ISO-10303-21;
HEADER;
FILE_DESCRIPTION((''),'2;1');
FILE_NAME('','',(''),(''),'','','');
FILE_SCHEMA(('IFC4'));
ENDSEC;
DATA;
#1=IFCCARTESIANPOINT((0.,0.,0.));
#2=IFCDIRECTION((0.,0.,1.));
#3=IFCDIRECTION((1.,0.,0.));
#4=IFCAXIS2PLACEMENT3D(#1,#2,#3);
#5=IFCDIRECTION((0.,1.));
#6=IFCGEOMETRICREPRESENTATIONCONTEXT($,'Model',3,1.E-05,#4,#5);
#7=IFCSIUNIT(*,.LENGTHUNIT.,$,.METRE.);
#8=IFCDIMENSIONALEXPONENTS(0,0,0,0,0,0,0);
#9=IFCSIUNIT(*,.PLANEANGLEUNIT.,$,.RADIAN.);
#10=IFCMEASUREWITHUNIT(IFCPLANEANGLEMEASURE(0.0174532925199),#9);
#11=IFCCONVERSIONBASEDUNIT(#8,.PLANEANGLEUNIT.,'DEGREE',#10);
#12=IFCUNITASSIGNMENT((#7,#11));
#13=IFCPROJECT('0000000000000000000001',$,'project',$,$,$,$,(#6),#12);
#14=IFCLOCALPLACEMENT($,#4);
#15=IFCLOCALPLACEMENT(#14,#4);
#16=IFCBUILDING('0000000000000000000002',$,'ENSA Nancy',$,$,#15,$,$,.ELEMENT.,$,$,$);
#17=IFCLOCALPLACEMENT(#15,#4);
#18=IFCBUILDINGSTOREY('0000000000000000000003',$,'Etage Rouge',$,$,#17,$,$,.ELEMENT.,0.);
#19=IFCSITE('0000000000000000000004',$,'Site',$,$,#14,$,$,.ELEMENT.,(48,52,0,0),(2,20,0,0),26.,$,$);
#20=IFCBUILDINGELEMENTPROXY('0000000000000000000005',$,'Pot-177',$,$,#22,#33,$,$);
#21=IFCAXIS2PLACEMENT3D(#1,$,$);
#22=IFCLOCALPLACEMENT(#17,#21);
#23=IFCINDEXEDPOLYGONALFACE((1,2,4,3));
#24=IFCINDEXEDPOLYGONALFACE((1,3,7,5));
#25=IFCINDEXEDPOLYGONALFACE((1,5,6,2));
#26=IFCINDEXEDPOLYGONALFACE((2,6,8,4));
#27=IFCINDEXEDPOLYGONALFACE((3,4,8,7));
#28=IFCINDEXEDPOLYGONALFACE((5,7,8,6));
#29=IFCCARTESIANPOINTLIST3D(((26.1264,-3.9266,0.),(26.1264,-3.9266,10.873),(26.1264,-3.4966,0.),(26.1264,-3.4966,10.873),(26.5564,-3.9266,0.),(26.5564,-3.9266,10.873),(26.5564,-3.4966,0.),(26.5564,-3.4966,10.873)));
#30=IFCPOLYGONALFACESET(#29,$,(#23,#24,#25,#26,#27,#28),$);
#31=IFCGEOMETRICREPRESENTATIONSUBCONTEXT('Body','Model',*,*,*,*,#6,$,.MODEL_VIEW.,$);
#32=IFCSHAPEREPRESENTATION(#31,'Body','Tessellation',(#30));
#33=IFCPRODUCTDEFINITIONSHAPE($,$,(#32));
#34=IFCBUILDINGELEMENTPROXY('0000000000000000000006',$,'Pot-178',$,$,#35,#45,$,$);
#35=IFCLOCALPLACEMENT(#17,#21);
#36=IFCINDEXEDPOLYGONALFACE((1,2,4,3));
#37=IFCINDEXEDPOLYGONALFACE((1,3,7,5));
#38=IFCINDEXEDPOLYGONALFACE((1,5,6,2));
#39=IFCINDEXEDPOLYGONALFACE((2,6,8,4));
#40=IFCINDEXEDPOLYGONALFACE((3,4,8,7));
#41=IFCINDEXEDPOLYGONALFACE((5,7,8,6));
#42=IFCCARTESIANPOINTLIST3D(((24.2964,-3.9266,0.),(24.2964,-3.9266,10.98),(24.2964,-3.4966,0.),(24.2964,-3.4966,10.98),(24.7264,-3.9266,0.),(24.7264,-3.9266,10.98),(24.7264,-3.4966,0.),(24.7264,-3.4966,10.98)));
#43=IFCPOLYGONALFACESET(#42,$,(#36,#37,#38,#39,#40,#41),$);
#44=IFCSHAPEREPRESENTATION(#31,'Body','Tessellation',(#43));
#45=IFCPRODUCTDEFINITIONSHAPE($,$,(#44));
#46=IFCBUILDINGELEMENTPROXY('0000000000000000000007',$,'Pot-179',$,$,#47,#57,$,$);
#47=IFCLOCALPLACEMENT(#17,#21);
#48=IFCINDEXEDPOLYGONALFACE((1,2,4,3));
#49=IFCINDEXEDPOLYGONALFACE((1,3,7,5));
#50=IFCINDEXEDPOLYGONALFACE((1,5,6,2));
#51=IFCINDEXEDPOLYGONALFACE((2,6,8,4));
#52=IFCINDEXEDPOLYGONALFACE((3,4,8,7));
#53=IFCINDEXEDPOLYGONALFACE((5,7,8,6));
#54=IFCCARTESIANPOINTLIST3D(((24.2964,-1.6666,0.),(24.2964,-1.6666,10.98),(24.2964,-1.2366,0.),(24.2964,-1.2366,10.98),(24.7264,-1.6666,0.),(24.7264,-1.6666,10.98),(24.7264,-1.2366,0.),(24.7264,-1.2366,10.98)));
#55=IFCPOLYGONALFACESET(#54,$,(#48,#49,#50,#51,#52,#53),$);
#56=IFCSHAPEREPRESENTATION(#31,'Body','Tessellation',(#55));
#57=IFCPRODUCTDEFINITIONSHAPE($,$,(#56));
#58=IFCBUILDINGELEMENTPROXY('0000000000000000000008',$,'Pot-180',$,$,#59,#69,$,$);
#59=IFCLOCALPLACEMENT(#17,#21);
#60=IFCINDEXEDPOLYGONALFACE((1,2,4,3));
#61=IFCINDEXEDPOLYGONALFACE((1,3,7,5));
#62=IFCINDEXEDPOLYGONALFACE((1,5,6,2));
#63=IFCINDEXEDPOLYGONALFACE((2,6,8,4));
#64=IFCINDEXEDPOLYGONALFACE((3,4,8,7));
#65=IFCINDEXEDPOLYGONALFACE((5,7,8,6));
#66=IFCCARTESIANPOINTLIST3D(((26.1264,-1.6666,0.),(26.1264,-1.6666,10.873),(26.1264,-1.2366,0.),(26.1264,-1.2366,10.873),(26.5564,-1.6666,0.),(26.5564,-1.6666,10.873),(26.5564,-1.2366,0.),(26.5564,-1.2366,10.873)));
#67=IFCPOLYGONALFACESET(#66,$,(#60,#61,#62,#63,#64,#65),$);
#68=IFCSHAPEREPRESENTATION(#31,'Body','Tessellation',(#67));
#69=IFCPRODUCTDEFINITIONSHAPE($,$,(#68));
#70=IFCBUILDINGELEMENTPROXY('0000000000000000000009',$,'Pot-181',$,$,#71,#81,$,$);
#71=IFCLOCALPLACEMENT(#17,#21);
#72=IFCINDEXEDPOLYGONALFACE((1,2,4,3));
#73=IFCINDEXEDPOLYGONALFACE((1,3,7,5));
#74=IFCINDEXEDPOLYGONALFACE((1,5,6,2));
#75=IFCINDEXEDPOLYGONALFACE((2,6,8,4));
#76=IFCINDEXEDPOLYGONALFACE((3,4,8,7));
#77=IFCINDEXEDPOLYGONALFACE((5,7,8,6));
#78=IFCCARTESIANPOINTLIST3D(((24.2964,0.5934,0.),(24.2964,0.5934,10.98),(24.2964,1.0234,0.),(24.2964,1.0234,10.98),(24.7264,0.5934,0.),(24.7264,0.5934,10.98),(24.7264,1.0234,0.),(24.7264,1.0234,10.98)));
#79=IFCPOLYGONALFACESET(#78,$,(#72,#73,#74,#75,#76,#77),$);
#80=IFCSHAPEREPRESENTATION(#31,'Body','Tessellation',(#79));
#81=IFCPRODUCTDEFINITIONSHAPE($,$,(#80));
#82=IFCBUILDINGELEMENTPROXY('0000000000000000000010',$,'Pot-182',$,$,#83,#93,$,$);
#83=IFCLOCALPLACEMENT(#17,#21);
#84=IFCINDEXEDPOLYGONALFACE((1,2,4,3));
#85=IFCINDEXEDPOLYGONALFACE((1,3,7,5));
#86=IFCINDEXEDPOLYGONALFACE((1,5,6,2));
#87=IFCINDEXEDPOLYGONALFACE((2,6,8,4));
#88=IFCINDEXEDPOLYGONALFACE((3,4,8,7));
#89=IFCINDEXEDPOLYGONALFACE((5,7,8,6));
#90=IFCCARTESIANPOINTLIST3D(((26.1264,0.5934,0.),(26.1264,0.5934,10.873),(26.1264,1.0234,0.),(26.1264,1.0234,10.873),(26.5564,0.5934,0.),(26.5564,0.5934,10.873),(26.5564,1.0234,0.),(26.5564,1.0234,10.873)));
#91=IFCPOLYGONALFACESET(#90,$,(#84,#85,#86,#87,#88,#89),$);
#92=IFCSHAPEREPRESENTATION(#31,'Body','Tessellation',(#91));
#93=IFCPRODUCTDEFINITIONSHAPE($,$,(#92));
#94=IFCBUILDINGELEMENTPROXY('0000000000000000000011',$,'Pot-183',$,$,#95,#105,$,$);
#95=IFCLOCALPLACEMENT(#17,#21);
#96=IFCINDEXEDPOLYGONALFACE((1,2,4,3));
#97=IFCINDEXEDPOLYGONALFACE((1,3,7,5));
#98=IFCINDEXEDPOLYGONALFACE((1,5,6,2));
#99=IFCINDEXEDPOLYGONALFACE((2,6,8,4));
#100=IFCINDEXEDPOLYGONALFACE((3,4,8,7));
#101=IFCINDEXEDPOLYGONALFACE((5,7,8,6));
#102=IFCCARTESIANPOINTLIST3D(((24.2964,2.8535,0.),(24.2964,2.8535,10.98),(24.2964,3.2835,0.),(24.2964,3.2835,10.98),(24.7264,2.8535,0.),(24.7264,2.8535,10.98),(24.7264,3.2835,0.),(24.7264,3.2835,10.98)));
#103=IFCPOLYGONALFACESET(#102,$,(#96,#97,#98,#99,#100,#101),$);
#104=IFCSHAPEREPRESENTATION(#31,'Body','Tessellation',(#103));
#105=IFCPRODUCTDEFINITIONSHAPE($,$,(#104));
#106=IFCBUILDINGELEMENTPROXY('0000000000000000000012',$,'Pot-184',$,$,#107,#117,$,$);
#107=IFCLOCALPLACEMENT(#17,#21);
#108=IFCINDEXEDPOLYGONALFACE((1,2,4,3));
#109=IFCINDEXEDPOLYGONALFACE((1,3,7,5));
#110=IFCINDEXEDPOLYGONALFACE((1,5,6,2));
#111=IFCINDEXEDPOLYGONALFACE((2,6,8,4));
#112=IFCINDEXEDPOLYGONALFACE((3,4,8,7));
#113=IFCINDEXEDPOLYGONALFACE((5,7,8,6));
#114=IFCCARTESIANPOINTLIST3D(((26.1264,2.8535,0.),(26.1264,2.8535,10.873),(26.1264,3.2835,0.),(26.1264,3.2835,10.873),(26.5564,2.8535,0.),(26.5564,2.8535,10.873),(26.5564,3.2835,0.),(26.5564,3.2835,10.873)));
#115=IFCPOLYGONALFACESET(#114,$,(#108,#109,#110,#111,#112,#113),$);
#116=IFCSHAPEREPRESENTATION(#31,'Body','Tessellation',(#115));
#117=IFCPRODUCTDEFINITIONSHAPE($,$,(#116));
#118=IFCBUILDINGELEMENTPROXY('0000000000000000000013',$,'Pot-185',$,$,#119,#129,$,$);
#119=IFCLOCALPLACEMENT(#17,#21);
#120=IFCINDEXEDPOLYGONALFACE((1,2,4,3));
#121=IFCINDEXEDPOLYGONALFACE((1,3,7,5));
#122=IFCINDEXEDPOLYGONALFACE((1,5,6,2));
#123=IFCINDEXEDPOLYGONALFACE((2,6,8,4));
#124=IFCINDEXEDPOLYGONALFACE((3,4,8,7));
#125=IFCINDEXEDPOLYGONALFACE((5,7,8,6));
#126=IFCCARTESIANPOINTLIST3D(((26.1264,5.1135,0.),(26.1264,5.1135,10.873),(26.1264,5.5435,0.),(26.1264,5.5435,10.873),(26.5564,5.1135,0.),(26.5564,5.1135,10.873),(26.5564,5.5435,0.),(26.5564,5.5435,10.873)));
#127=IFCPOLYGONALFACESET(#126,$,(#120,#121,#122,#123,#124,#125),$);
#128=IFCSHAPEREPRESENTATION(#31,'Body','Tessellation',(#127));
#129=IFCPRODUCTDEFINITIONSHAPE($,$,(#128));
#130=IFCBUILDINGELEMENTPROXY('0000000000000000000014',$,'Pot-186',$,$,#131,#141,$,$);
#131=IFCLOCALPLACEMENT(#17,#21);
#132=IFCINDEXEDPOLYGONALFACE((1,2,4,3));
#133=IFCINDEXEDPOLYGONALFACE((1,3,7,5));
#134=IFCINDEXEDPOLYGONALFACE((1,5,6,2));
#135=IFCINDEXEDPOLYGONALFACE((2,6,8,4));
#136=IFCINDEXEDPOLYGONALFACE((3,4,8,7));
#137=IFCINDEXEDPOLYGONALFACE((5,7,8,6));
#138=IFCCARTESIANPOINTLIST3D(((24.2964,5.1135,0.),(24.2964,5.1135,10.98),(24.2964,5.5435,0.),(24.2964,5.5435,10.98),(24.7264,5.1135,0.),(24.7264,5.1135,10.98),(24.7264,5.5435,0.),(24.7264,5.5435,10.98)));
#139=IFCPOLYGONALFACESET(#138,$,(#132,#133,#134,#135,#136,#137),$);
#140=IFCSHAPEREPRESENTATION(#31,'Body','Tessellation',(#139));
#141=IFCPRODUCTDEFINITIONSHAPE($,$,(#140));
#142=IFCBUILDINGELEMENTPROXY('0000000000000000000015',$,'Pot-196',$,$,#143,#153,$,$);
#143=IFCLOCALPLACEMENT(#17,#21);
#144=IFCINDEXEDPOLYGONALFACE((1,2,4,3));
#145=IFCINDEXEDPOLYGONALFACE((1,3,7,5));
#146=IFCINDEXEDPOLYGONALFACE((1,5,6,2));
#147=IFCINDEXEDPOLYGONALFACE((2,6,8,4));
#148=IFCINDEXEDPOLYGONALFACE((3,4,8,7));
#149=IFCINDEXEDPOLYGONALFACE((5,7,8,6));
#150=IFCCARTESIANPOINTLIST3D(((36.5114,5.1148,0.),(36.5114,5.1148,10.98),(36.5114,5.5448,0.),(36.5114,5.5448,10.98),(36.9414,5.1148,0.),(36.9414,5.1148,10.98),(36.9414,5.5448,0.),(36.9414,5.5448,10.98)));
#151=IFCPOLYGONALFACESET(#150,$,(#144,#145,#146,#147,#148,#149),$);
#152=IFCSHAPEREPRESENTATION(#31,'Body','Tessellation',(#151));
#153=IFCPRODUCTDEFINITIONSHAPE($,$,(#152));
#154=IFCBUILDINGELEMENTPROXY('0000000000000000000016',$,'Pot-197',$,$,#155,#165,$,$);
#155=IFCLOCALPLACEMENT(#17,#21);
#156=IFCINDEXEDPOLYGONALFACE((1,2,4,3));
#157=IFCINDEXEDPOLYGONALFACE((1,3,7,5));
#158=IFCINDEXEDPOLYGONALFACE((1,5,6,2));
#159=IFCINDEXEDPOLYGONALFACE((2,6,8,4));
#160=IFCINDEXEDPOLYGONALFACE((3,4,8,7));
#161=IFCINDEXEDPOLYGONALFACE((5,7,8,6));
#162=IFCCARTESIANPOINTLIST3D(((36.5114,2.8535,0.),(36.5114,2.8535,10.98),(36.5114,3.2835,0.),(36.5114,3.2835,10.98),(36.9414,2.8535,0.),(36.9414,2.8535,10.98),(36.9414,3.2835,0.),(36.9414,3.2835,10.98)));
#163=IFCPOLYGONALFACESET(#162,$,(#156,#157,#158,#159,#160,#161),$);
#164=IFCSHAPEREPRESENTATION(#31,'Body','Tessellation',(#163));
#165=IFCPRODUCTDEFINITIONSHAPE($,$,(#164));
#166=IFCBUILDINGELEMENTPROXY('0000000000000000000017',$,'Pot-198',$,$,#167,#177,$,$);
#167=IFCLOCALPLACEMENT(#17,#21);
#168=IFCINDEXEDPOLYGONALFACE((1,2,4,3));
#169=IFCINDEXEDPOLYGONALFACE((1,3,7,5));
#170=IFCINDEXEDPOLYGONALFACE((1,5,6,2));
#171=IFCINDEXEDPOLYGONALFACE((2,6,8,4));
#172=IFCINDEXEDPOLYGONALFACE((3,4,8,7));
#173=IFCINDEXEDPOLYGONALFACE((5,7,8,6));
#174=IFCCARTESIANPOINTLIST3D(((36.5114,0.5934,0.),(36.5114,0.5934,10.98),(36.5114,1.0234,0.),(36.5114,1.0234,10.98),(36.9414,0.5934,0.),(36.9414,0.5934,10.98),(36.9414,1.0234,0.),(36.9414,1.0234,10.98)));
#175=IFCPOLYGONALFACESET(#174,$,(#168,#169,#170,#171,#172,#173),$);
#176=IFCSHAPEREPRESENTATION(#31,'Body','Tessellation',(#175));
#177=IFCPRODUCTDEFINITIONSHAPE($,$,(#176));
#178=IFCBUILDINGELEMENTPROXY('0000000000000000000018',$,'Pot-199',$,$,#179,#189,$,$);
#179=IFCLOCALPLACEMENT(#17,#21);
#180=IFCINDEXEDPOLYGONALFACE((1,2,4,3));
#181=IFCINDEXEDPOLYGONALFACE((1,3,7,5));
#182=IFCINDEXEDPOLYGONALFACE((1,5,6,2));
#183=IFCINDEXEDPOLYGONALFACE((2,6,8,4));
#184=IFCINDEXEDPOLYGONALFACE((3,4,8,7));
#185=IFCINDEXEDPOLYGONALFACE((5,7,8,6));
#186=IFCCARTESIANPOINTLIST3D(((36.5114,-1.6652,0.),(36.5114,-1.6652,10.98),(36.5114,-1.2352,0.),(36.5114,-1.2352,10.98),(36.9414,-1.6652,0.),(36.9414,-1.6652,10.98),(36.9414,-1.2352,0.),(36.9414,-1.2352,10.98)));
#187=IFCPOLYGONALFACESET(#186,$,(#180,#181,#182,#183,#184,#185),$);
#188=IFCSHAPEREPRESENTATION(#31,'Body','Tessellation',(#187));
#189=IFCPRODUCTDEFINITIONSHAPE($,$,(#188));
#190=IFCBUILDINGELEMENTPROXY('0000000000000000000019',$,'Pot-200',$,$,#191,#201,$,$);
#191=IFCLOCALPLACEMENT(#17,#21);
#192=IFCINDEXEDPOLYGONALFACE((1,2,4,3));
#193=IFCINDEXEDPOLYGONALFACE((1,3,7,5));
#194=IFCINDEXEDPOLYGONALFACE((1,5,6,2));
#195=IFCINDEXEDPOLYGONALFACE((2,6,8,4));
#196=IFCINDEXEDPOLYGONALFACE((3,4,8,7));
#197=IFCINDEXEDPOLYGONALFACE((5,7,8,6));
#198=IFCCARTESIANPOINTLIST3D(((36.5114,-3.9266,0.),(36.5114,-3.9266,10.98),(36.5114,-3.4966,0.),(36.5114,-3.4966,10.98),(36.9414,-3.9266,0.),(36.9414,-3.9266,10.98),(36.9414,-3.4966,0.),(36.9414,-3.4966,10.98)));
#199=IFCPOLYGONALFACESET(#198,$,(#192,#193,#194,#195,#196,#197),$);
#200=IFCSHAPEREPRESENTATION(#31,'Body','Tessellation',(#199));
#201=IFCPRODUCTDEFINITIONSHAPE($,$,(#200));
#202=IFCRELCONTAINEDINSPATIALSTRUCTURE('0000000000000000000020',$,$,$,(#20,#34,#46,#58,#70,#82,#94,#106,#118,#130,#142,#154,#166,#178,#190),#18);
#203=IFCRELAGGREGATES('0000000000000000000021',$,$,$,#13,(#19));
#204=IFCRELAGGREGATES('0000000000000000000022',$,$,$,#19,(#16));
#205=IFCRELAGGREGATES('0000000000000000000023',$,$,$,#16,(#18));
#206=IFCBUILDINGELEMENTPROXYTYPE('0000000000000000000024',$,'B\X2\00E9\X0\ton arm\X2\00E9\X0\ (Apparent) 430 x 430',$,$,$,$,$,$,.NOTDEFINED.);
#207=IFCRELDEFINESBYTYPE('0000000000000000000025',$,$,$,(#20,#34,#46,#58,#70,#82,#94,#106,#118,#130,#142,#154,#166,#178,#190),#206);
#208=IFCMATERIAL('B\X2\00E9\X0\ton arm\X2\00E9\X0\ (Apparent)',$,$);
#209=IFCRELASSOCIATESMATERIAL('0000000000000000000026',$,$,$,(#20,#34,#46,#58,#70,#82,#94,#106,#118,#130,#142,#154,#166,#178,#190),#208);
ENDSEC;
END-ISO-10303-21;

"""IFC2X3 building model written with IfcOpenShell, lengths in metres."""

from ifc_helpers import new_model, entity, si_unit, converted_unit, direction, frame, origin_with_axes, origin_2d_with_axis, place, context, subcontext, project, spatial, rectangle, extrude, material, type_object, element, save


model = new_model("IFC2X3")

# Units and contexts
model_context = context("Model", 3, precision=1e-05, world=origin_with_axes(), true_north=direction((0.0, 1.0)))
body_context = subcontext(model_context, "Body", "Model", "MODEL_VIEW")
ifc_project = project(units=[si_unit("LENGTHUNIT", "METRE"), converted_unit("PLANEANGLEUNIT", "DEGREE", entity("IfcPlaneAngleMeasure", 0.0174532925199), si_unit("PLANEANGLEUNIT", "RADIAN"), dimensions=[0, 0, 0, 0, 0, 0, 0])], contexts=[model_context])

# Site, building, storey
site_placement = place(None, origin_with_axes())
site = spatial("IfcSite", under=ifc_project, at=site_placement, Name="Site", CompositionType="ELEMENT", RefLatitude=(48, 52, 0, 0), RefLongitude=(2, 20, 0, 0), RefElevation=26.0)
building_placement = place(site_placement, origin_with_axes())
building = spatial("IfcBuilding", under=site, at=building_placement, Name="ENSA Nancy", CompositionType="ELEMENT")
storey_placement = place(building_placement, origin_with_axes())
storey = spatial("IfcBuildingStorey", under=building, at=storey_placement, Name="Etage Rouge", CompositionType="ELEMENT", Elevation=0.0)

# Building element proxies
ifc_material_1 = material(Name="Béton armé (Apparent)")
building_element_proxy_type_1 = type_object("IfcBuildingElementProxyType", Name="Béton armé (Apparent) 430 x 430", PredefinedType="NOTDEFINED")
proxy_1_placement = place(storey_placement, frame((26.3414, -3.7116, 0.0), z_axis=(0.0, 0.0, 1.0), x_axis=(1.0, 0.0, 0.0)))
element("IfcBuildingElementProxy", 1, at=proxy_1_placement, inside=storey, type_object=building_element_proxy_type_1, material=ifc_material_1, Name="Pot-177", context=body_context, shape_type="SweptSolid", body=[
    extrude(rectangle(XDim=0.43, YDim=0.43, at=origin_2d_with_axis()), origin_with_axes(), (0.0, 0.0, 1.0), 10.873),
])
for number, where, z_axis, x_axis, name in (
    (2, (24.5114, -3.7116, 0.0), (0.0, 0.0, 1.0), (1.0, 0.0, 0.0), "Pot-178"),
    (3, (24.5114, -1.4516, 0.0), (0.0, 0.0, 1.0), (1.0, 0.0, 0.0), "Pot-179"),
):
    element("IfcBuildingElementProxy", number, at=place(storey_placement, frame(where, z_axis=z_axis, x_axis=x_axis)), inside=storey, type_object=building_element_proxy_type_1, material=ifc_material_1, Name=name, context=body_context, shape_type="SweptSolid", body=[
        extrude(rectangle(XDim=0.43, YDim=0.43, at=origin_2d_with_axis()), origin_with_axes(), (0.0, 0.0, 1.0), 10.98),
    ])
proxy_2_placement = place(storey_placement, frame((26.3414, -1.4516, 0.0), z_axis=(0.0, 0.0, 1.0), x_axis=(1.0, 0.0, 0.0)))
element("IfcBuildingElementProxy", 4, at=proxy_2_placement, inside=storey, type_object=building_element_proxy_type_1, material=ifc_material_1, Name="Pot-180", context=body_context, shape_type="SweptSolid", body=[
    extrude(rectangle(XDim=0.43, YDim=0.43, at=origin_2d_with_axis()), origin_with_axes(), (0.0, 0.0, 1.0), 10.873),
])
proxy_3_placement = place(storey_placement, frame((24.5114, 0.8084, 0.0), z_axis=(0.0, 0.0, 1.0), x_axis=(1.0, 0.0, 0.0)))
element("IfcBuildingElementProxy", 5, at=proxy_3_placement, inside=storey, type_object=building_element_proxy_type_1, material=ifc_material_1, Name="Pot-181", context=body_context, shape_type="SweptSolid", body=[
    extrude(rectangle(XDim=0.43, YDim=0.43, at=origin_2d_with_axis()), origin_with_axes(), (0.0, 0.0, 1.0), 10.98),
])
proxy_4_placement = place(storey_placement, frame((26.3414, 0.8084, 0.0), z_axis=(0.0, 0.0, 1.0), x_axis=(1.0, 0.0, 0.0)))
element("IfcBuildingElementProxy", 6, at=proxy_4_placement, inside=storey, type_object=building_element_proxy_type_1, material=ifc_material_1, Name="Pot-182", context=body_context, shape_type="SweptSolid", body=[
    extrude(rectangle(XDim=0.43, YDim=0.43, at=origin_2d_with_axis()), origin_with_axes(), (0.0, 0.0, 1.0), 10.873),
])
proxy_5_placement = place(storey_placement, frame((24.5114, 3.0685, 0.0), z_axis=(0.0, 0.0, 1.0), x_axis=(1.0, 0.0, 0.0)))
element("IfcBuildingElementProxy", 7, at=proxy_5_placement, inside=storey, type_object=building_element_proxy_type_1, material=ifc_material_1, Name="Pot-183", context=body_context, shape_type="SweptSolid", body=[
    extrude(rectangle(XDim=0.43, YDim=0.43, at=origin_2d_with_axis()), origin_with_axes(), (0.0, 0.0, 1.0), 10.98),
])
for number, where, z_axis, x_axis, name in (
    (8, (26.3414, 3.0685, 0.0), (0.0, 0.0, 1.0), (1.0, 0.0, 0.0), "Pot-184"),
    (9, (26.3414, 5.3285, 0.0), (0.0, 0.0, 1.0), (1.0, 0.0, 0.0), "Pot-185"),
):
    element("IfcBuildingElementProxy", number, at=place(storey_placement, frame(where, z_axis=z_axis, x_axis=x_axis)), inside=storey, type_object=building_element_proxy_type_1, material=ifc_material_1, Name=name, context=body_context, shape_type="SweptSolid", body=[
        extrude(rectangle(XDim=0.43, YDim=0.43, at=origin_2d_with_axis()), origin_with_axes(), (0.0, 0.0, 1.0), 10.873),
    ])
for number, where, z_axis, x_axis, name in (
    (10, (24.5114, 5.3285, 0.0), (0.0, 0.0, 1.0), (1.0, 0.0, 0.0), "Pot-186"),
    (11, (36.7264, 5.3298, 0.0), (0.0, 0.0, 1.0), (1.0, 0.0, 0.0), "Pot-196"),
    (12, (36.7264, 3.0685, 0.0), (0.0, 0.0, 1.0), (1.0, 0.0, 0.0), "Pot-197"),
    (13, (36.7264, 0.8084, 0.0), (0.0, 0.0, 1.0), (1.0, 0.0, 0.0), "Pot-198"),
    (14, (36.7264, -1.4502, 0.0), (0.0, 0.0, 1.0), (1.0, 0.0, 0.0), "Pot-199"),
    (15, (36.7264, -3.7116, 0.0), (0.0, 0.0, 1.0), (1.0, 0.0, 0.0), "Pot-200"),
):
    element("IfcBuildingElementProxy", number, at=place(storey_placement, frame(where, z_axis=z_axis, x_axis=x_axis)), inside=storey, type_object=building_element_proxy_type_1, material=ifc_material_1, Name=name, context=body_context, shape_type="SweptSolid", body=[
        extrude(rectangle(XDim=0.43, YDim=0.43, at=origin_2d_with_axis()), origin_with_axes(), (0.0, 0.0, 1.0), 10.98),
    ])

save(model, "model.ifc")
